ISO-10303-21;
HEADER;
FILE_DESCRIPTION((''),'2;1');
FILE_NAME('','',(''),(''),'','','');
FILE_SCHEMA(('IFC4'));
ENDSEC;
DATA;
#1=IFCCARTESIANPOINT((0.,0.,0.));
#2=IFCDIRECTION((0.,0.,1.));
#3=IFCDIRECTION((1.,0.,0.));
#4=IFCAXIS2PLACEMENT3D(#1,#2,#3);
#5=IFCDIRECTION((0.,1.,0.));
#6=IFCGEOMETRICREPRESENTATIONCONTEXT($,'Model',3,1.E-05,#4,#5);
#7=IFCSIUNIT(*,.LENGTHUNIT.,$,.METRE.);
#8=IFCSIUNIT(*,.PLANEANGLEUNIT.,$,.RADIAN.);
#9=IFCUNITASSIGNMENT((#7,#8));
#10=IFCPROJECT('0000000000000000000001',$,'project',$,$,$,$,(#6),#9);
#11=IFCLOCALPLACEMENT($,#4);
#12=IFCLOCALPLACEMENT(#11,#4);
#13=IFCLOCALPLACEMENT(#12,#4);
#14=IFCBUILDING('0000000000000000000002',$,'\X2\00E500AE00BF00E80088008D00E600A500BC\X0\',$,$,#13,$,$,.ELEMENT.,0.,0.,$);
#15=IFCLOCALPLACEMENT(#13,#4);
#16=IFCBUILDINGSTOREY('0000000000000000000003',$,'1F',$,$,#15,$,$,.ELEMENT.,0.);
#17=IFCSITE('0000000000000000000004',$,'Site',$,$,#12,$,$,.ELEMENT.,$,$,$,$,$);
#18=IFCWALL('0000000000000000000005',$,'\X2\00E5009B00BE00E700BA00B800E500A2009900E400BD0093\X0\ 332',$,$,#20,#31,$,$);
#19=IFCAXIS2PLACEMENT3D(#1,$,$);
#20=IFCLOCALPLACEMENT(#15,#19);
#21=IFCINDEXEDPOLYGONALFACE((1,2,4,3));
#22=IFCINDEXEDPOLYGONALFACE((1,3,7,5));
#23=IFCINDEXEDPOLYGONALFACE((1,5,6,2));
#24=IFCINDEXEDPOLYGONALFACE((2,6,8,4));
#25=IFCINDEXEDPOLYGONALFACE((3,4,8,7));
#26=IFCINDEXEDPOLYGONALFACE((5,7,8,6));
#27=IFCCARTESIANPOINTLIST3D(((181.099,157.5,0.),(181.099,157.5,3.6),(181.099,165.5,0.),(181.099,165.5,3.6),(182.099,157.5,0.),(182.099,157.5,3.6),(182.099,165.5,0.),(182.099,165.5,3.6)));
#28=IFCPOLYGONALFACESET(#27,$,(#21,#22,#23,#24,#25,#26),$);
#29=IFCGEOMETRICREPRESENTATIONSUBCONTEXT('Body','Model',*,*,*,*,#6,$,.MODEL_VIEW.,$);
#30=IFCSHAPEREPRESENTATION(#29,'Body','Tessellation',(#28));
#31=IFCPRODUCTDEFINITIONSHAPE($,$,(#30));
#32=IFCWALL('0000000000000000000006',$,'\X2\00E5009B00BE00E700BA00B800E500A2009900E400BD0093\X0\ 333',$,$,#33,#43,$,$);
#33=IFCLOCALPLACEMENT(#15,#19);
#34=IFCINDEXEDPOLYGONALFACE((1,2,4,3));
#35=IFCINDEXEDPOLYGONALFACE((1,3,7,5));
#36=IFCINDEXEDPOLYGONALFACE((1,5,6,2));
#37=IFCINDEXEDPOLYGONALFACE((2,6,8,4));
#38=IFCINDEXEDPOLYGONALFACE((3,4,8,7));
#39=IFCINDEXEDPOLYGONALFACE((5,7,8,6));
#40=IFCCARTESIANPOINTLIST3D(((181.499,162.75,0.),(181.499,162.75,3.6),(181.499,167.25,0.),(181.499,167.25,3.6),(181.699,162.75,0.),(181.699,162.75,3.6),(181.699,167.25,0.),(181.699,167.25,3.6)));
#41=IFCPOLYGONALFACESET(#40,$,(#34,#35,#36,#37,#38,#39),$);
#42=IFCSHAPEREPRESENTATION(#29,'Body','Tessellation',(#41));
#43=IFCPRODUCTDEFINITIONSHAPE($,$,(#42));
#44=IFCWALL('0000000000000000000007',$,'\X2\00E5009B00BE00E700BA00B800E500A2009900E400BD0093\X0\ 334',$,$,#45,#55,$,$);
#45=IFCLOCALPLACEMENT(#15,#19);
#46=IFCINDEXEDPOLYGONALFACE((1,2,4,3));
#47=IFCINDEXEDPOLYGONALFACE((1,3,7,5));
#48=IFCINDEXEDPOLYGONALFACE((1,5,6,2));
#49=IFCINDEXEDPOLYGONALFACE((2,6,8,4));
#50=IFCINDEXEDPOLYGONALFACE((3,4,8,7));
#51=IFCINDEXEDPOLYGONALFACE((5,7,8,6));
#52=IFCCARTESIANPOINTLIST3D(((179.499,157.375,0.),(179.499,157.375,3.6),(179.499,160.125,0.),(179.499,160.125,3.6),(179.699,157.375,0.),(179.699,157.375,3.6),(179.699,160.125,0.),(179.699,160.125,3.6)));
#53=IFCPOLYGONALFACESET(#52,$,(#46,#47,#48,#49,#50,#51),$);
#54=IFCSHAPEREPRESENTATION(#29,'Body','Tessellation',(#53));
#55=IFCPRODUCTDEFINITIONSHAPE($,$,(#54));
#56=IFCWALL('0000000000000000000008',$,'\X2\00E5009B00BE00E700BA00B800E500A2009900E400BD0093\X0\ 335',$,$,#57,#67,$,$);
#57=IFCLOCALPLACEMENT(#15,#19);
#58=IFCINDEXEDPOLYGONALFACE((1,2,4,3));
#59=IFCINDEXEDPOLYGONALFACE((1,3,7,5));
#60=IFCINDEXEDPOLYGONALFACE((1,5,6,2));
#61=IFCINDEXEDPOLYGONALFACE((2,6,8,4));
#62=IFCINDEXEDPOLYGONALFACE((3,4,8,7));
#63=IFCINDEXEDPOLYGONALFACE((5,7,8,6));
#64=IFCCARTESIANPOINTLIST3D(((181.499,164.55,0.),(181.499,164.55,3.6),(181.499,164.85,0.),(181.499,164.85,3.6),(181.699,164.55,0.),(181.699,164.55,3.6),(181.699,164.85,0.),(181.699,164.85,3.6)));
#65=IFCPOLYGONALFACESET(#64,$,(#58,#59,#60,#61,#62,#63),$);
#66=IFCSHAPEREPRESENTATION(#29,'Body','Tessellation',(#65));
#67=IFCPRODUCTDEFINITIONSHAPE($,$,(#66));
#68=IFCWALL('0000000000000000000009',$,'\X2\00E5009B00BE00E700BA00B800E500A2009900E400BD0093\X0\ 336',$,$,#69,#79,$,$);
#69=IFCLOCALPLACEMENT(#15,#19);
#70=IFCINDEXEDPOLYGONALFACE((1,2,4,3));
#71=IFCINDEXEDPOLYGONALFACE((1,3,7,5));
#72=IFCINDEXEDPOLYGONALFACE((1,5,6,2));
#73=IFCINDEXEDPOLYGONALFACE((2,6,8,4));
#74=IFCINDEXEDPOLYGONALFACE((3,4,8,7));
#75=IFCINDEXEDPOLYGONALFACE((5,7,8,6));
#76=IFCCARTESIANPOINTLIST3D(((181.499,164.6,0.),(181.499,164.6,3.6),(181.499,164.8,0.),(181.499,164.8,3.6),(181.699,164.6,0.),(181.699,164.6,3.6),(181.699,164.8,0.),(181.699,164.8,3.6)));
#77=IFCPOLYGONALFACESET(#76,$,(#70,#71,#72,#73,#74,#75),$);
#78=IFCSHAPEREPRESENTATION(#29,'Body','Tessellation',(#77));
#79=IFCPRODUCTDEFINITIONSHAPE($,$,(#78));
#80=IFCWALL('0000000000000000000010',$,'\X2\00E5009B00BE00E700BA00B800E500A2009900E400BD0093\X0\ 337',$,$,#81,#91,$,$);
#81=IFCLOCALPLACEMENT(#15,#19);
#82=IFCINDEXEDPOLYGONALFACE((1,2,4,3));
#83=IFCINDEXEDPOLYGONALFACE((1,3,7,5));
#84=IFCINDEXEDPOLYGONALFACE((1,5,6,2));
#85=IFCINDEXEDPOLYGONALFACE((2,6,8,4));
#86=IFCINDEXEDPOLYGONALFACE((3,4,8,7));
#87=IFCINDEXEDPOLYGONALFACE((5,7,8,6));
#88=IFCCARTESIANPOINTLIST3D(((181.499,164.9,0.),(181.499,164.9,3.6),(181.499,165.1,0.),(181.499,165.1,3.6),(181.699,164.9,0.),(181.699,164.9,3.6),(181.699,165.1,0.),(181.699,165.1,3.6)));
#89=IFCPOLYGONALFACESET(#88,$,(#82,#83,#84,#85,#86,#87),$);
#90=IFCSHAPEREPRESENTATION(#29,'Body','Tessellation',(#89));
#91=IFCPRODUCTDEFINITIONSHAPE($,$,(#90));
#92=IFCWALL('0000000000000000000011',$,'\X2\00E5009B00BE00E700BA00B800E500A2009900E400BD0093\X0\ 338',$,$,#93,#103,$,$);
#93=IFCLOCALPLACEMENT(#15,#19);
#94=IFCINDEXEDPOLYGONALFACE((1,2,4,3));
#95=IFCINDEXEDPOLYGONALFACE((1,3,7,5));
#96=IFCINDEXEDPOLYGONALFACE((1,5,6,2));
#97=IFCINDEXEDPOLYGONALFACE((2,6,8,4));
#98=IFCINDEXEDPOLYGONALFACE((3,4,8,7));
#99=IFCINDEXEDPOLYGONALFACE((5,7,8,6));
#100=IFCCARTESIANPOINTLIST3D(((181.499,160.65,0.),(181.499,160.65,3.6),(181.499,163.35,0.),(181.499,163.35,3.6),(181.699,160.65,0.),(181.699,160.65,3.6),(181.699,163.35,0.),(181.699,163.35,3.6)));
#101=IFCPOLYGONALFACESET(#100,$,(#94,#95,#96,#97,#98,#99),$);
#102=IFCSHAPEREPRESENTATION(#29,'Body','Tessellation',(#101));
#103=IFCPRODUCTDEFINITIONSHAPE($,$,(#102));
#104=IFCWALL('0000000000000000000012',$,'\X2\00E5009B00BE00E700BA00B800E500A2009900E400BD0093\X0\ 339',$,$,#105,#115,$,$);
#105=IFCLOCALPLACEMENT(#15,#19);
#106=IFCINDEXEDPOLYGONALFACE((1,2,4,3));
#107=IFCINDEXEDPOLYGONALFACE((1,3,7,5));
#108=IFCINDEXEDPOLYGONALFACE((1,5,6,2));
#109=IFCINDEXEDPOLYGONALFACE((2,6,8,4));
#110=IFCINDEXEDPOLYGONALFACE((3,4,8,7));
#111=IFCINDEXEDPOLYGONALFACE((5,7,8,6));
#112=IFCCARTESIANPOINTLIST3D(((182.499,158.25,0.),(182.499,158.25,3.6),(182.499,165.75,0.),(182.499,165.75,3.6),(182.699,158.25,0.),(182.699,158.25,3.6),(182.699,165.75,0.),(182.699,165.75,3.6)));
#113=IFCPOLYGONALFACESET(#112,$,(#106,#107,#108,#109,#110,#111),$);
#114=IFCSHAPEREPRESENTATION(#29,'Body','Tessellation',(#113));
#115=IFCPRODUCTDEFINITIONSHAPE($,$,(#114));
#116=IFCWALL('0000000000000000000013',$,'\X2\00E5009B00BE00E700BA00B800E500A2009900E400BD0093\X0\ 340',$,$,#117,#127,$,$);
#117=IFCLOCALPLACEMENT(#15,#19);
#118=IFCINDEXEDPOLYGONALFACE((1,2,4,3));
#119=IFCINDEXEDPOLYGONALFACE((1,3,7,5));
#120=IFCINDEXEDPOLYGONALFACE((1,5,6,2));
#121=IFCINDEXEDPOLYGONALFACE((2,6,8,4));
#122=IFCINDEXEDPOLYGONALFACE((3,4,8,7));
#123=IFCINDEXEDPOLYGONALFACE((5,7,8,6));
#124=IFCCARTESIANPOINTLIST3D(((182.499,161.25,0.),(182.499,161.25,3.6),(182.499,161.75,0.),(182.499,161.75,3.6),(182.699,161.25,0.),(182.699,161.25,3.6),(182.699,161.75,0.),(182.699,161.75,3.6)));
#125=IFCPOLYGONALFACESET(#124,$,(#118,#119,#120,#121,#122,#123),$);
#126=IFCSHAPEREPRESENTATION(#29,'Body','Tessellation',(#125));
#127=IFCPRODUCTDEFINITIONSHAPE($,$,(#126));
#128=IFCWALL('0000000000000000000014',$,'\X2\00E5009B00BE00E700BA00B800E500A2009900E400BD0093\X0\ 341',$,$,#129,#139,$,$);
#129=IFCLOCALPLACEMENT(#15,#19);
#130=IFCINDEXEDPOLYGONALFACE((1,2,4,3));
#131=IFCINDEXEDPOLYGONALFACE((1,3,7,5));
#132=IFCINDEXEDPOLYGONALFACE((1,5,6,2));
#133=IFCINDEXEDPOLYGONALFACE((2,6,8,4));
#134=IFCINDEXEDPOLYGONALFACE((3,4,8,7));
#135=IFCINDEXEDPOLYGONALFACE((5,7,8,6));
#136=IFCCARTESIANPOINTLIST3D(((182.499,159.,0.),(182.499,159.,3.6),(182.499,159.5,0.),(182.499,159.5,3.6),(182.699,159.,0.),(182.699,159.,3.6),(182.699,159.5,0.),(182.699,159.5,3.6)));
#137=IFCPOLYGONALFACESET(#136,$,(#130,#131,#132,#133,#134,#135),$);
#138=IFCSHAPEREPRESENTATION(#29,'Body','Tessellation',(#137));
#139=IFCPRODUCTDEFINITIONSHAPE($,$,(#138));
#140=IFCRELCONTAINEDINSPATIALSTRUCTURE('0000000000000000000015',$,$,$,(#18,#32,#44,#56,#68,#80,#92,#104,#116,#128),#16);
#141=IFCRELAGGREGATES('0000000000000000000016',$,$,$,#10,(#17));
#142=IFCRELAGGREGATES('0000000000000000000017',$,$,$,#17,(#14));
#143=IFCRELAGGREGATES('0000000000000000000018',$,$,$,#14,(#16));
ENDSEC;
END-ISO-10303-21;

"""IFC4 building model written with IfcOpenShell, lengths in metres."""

from ifc_helpers import new_model, si_unit, direction, frame, frame_2d, origin_with_axes, place, context, subcontext, project, spatial, rectangle, extrude, element, save


model = new_model("IFC4")

# Units and contexts
model_context = context("Model", 3, precision=1e-05, world=origin_with_axes(), true_north=direction((0.0, 1.0, 0.0)))
body_context = subcontext(model_context, "Body", "Model", "MODEL_VIEW")
ifc_project = project(units=[si_unit("LENGTHUNIT", "METRE"), si_unit("PLANEANGLEUNIT", "RADIAN")], contexts=[model_context])

# Site, building, storey
placement = place(None, origin_with_axes())
site_placement = place(placement, origin_with_axes())
site = spatial("IfcSite", under=ifc_project, at=site_placement, Name="Site", CompositionType="ELEMENT")
building_placement = place(site_placement, origin_with_axes())
building = spatial("IfcBuilding", under=site, at=building_placement, Name="å®¿è\u0088\u008dæ¥¼", CompositionType="ELEMENT", ElevationOfRefHeight=0.0, ElevationOfTerrain=0.0)
storey_placement = place(building_placement, origin_with_axes())
storey = spatial("IfcBuildingStorey", under=building, at=storey_placement, Name="1F", CompositionType="ELEMENT", Elevation=0.0)

# Walls
wall_1_placement = place(storey_placement, frame((181.599, 161.5, 0.0), z_axis=(0.0, 0.0, 1.0), x_axis=(1.0, 0.0, 0.0)))
element("IfcWall", 1, at=wall_1_placement, inside=storey, Name="å\u009b¾çº¸å¢\u0099ä½\u0093 332", context=body_context, shape_type="SweptSolid", body=[
    extrude(rectangle(XDim=1.0, YDim=8.0, at=frame_2d((0.0, 0.0), x_axis=(1.0, 0.0, 0.0))), frame((0.0, 0.0, 0.0), z_axis=(0.0, 0.0, 1.0)), (0.0, 0.0, 1.0), 3.6),
])
wall_2_placement = place(storey_placement, frame((181.599, 165.0, 0.0), z_axis=(0.0, 0.0, 1.0), x_axis=(0.0, 1.0, 0.0)))
element("IfcWall", 2, at=wall_2_placement, inside=storey, Name="å\u009b¾çº¸å¢\u0099ä½\u0093 333", context=body_context, shape_type="SweptSolid", body=[
    extrude(rectangle(XDim=4.5, YDim=0.2, at=frame_2d((0.0, 0.0), x_axis=(1.0, 0.0, 0.0))), frame((0.0, 0.0, 0.0), z_axis=(0.0, 0.0, 1.0)), (0.0, 0.0, 1.0), 3.6),
])
wall_3_placement = place(storey_placement, frame((179.599, 158.75, 0.0), z_axis=(0.0, 0.0, 1.0), x_axis=(0.0, 1.0, 0.0)))
element("IfcWall", 3, at=wall_3_placement, inside=storey, Name="å\u009b¾çº¸å¢\u0099ä½\u0093 334", context=body_context, shape_type="SweptSolid", body=[
    extrude(rectangle(XDim=2.75, YDim=0.2, at=frame_2d((0.0, 0.0), x_axis=(1.0, 0.0, 0.0))), frame((0.0, 0.0, 0.0), z_axis=(0.0, 0.0, 1.0)), (0.0, 0.0, 1.0), 3.6),
])
wall_4_placement = place(storey_placement, frame((181.599, 164.7, 0.0), z_axis=(0.0, 0.0, 1.0), x_axis=(1.0, 0.0, 0.0)))
element("IfcWall", 4, at=wall_4_placement, inside=storey, Name="å\u009b¾çº¸å¢\u0099ä½\u0093 335", context=body_context, shape_type="SweptSolid", body=[
    extrude(rectangle(XDim=0.2, YDim=0.3, at=frame_2d((0.0, 0.0), x_axis=(1.0, 0.0, 0.0))), frame((0.0, 0.0, 0.0), z_axis=(0.0, 0.0, 1.0)), (0.0, 0.0, 1.0), 3.6),
])
for number, where, z_axis, x_axis, name in (
    (5, (181.599, 164.7, 0.0), (0.0, 0.0, 1.0), (1.0, 0.0, 0.0), "å\u009b¾çº¸å¢\u0099ä½\u0093 336"),
    (6, (181.599, 165.0, 0.0), (0.0, 0.0, 1.0), (1.0, 0.0, 0.0), "å\u009b¾çº¸å¢\u0099ä½\u0093 337"),
):
    element("IfcWall", number, at=place(storey_placement, frame(where, z_axis=z_axis, x_axis=x_axis)), inside=storey, Name=name, context=body_context, shape_type="SweptSolid", body=[
        extrude(rectangle(XDim=0.2, YDim=0.2, at=frame_2d((0.0, 0.0), x_axis=(1.0, 0.0, 0.0))), frame((0.0, 0.0, 0.0), z_axis=(0.0, 0.0, 1.0)), (0.0, 0.0, 1.0), 3.6),
    ])
wall_5_placement = place(storey_placement, frame((181.599, 162.0, 0.0), z_axis=(0.0, 0.0, 1.0), x_axis=(0.0, 1.0, 0.0)))
element("IfcWall", 7, at=wall_5_placement, inside=storey, Name="å\u009b¾çº¸å¢\u0099ä½\u0093 338", context=body_context, shape_type="SweptSolid", body=[
    extrude(rectangle(XDim=2.7, YDim=0.2, at=frame_2d((0.0, 0.0), x_axis=(1.0, 0.0, 0.0))), frame((0.0, 0.0, 0.0), z_axis=(0.0, 0.0, 1.0)), (0.0, 0.0, 1.0), 3.6),
])
wall_6_placement = place(storey_placement, frame((182.599, 162.0, 0.0), z_axis=(0.0, 0.0, 1.0), x_axis=(0.0, 1.0, 0.0)))
element("IfcWall", 8, at=wall_6_placement, inside=storey, Name="å\u009b¾çº¸å¢\u0099ä½\u0093 339", context=body_context, shape_type="SweptSolid", body=[
    extrude(rectangle(XDim=7.5, YDim=0.2, at=frame_2d((0.0, 0.0), x_axis=(1.0, 0.0, 0.0))), frame((0.0, 0.0, 0.0), z_axis=(0.0, 0.0, 1.0)), (0.0, 0.0, 1.0), 3.6),
])
for number, where, z_axis, x_axis, name in (
    (9, (182.599, 161.5, 0.0), (0.0, 0.0, 1.0), (0.0, 1.0, 0.0), "å\u009b¾çº¸å¢\u0099ä½\u0093 340"),
    (10, (182.599, 159.25, 0.0), (0.0, 0.0, 1.0), (0.0, -1.0, 0.0), "å\u009b¾çº¸å¢\u0099ä½\u0093 341"),
):
    element("IfcWall", number, at=place(storey_placement, frame(where, z_axis=z_axis, x_axis=x_axis)), inside=storey, Name=name, context=body_context, shape_type="SweptSolid", body=[
        extrude(rectangle(XDim=0.5, YDim=0.2, at=frame_2d((0.0, 0.0), x_axis=(1.0, 0.0, 0.0))), frame((0.0, 0.0, 0.0), z_axis=(0.0, 0.0, 1.0)), (0.0, 0.0, 1.0), 3.6),
    ])

save(model, "model.ifc")
